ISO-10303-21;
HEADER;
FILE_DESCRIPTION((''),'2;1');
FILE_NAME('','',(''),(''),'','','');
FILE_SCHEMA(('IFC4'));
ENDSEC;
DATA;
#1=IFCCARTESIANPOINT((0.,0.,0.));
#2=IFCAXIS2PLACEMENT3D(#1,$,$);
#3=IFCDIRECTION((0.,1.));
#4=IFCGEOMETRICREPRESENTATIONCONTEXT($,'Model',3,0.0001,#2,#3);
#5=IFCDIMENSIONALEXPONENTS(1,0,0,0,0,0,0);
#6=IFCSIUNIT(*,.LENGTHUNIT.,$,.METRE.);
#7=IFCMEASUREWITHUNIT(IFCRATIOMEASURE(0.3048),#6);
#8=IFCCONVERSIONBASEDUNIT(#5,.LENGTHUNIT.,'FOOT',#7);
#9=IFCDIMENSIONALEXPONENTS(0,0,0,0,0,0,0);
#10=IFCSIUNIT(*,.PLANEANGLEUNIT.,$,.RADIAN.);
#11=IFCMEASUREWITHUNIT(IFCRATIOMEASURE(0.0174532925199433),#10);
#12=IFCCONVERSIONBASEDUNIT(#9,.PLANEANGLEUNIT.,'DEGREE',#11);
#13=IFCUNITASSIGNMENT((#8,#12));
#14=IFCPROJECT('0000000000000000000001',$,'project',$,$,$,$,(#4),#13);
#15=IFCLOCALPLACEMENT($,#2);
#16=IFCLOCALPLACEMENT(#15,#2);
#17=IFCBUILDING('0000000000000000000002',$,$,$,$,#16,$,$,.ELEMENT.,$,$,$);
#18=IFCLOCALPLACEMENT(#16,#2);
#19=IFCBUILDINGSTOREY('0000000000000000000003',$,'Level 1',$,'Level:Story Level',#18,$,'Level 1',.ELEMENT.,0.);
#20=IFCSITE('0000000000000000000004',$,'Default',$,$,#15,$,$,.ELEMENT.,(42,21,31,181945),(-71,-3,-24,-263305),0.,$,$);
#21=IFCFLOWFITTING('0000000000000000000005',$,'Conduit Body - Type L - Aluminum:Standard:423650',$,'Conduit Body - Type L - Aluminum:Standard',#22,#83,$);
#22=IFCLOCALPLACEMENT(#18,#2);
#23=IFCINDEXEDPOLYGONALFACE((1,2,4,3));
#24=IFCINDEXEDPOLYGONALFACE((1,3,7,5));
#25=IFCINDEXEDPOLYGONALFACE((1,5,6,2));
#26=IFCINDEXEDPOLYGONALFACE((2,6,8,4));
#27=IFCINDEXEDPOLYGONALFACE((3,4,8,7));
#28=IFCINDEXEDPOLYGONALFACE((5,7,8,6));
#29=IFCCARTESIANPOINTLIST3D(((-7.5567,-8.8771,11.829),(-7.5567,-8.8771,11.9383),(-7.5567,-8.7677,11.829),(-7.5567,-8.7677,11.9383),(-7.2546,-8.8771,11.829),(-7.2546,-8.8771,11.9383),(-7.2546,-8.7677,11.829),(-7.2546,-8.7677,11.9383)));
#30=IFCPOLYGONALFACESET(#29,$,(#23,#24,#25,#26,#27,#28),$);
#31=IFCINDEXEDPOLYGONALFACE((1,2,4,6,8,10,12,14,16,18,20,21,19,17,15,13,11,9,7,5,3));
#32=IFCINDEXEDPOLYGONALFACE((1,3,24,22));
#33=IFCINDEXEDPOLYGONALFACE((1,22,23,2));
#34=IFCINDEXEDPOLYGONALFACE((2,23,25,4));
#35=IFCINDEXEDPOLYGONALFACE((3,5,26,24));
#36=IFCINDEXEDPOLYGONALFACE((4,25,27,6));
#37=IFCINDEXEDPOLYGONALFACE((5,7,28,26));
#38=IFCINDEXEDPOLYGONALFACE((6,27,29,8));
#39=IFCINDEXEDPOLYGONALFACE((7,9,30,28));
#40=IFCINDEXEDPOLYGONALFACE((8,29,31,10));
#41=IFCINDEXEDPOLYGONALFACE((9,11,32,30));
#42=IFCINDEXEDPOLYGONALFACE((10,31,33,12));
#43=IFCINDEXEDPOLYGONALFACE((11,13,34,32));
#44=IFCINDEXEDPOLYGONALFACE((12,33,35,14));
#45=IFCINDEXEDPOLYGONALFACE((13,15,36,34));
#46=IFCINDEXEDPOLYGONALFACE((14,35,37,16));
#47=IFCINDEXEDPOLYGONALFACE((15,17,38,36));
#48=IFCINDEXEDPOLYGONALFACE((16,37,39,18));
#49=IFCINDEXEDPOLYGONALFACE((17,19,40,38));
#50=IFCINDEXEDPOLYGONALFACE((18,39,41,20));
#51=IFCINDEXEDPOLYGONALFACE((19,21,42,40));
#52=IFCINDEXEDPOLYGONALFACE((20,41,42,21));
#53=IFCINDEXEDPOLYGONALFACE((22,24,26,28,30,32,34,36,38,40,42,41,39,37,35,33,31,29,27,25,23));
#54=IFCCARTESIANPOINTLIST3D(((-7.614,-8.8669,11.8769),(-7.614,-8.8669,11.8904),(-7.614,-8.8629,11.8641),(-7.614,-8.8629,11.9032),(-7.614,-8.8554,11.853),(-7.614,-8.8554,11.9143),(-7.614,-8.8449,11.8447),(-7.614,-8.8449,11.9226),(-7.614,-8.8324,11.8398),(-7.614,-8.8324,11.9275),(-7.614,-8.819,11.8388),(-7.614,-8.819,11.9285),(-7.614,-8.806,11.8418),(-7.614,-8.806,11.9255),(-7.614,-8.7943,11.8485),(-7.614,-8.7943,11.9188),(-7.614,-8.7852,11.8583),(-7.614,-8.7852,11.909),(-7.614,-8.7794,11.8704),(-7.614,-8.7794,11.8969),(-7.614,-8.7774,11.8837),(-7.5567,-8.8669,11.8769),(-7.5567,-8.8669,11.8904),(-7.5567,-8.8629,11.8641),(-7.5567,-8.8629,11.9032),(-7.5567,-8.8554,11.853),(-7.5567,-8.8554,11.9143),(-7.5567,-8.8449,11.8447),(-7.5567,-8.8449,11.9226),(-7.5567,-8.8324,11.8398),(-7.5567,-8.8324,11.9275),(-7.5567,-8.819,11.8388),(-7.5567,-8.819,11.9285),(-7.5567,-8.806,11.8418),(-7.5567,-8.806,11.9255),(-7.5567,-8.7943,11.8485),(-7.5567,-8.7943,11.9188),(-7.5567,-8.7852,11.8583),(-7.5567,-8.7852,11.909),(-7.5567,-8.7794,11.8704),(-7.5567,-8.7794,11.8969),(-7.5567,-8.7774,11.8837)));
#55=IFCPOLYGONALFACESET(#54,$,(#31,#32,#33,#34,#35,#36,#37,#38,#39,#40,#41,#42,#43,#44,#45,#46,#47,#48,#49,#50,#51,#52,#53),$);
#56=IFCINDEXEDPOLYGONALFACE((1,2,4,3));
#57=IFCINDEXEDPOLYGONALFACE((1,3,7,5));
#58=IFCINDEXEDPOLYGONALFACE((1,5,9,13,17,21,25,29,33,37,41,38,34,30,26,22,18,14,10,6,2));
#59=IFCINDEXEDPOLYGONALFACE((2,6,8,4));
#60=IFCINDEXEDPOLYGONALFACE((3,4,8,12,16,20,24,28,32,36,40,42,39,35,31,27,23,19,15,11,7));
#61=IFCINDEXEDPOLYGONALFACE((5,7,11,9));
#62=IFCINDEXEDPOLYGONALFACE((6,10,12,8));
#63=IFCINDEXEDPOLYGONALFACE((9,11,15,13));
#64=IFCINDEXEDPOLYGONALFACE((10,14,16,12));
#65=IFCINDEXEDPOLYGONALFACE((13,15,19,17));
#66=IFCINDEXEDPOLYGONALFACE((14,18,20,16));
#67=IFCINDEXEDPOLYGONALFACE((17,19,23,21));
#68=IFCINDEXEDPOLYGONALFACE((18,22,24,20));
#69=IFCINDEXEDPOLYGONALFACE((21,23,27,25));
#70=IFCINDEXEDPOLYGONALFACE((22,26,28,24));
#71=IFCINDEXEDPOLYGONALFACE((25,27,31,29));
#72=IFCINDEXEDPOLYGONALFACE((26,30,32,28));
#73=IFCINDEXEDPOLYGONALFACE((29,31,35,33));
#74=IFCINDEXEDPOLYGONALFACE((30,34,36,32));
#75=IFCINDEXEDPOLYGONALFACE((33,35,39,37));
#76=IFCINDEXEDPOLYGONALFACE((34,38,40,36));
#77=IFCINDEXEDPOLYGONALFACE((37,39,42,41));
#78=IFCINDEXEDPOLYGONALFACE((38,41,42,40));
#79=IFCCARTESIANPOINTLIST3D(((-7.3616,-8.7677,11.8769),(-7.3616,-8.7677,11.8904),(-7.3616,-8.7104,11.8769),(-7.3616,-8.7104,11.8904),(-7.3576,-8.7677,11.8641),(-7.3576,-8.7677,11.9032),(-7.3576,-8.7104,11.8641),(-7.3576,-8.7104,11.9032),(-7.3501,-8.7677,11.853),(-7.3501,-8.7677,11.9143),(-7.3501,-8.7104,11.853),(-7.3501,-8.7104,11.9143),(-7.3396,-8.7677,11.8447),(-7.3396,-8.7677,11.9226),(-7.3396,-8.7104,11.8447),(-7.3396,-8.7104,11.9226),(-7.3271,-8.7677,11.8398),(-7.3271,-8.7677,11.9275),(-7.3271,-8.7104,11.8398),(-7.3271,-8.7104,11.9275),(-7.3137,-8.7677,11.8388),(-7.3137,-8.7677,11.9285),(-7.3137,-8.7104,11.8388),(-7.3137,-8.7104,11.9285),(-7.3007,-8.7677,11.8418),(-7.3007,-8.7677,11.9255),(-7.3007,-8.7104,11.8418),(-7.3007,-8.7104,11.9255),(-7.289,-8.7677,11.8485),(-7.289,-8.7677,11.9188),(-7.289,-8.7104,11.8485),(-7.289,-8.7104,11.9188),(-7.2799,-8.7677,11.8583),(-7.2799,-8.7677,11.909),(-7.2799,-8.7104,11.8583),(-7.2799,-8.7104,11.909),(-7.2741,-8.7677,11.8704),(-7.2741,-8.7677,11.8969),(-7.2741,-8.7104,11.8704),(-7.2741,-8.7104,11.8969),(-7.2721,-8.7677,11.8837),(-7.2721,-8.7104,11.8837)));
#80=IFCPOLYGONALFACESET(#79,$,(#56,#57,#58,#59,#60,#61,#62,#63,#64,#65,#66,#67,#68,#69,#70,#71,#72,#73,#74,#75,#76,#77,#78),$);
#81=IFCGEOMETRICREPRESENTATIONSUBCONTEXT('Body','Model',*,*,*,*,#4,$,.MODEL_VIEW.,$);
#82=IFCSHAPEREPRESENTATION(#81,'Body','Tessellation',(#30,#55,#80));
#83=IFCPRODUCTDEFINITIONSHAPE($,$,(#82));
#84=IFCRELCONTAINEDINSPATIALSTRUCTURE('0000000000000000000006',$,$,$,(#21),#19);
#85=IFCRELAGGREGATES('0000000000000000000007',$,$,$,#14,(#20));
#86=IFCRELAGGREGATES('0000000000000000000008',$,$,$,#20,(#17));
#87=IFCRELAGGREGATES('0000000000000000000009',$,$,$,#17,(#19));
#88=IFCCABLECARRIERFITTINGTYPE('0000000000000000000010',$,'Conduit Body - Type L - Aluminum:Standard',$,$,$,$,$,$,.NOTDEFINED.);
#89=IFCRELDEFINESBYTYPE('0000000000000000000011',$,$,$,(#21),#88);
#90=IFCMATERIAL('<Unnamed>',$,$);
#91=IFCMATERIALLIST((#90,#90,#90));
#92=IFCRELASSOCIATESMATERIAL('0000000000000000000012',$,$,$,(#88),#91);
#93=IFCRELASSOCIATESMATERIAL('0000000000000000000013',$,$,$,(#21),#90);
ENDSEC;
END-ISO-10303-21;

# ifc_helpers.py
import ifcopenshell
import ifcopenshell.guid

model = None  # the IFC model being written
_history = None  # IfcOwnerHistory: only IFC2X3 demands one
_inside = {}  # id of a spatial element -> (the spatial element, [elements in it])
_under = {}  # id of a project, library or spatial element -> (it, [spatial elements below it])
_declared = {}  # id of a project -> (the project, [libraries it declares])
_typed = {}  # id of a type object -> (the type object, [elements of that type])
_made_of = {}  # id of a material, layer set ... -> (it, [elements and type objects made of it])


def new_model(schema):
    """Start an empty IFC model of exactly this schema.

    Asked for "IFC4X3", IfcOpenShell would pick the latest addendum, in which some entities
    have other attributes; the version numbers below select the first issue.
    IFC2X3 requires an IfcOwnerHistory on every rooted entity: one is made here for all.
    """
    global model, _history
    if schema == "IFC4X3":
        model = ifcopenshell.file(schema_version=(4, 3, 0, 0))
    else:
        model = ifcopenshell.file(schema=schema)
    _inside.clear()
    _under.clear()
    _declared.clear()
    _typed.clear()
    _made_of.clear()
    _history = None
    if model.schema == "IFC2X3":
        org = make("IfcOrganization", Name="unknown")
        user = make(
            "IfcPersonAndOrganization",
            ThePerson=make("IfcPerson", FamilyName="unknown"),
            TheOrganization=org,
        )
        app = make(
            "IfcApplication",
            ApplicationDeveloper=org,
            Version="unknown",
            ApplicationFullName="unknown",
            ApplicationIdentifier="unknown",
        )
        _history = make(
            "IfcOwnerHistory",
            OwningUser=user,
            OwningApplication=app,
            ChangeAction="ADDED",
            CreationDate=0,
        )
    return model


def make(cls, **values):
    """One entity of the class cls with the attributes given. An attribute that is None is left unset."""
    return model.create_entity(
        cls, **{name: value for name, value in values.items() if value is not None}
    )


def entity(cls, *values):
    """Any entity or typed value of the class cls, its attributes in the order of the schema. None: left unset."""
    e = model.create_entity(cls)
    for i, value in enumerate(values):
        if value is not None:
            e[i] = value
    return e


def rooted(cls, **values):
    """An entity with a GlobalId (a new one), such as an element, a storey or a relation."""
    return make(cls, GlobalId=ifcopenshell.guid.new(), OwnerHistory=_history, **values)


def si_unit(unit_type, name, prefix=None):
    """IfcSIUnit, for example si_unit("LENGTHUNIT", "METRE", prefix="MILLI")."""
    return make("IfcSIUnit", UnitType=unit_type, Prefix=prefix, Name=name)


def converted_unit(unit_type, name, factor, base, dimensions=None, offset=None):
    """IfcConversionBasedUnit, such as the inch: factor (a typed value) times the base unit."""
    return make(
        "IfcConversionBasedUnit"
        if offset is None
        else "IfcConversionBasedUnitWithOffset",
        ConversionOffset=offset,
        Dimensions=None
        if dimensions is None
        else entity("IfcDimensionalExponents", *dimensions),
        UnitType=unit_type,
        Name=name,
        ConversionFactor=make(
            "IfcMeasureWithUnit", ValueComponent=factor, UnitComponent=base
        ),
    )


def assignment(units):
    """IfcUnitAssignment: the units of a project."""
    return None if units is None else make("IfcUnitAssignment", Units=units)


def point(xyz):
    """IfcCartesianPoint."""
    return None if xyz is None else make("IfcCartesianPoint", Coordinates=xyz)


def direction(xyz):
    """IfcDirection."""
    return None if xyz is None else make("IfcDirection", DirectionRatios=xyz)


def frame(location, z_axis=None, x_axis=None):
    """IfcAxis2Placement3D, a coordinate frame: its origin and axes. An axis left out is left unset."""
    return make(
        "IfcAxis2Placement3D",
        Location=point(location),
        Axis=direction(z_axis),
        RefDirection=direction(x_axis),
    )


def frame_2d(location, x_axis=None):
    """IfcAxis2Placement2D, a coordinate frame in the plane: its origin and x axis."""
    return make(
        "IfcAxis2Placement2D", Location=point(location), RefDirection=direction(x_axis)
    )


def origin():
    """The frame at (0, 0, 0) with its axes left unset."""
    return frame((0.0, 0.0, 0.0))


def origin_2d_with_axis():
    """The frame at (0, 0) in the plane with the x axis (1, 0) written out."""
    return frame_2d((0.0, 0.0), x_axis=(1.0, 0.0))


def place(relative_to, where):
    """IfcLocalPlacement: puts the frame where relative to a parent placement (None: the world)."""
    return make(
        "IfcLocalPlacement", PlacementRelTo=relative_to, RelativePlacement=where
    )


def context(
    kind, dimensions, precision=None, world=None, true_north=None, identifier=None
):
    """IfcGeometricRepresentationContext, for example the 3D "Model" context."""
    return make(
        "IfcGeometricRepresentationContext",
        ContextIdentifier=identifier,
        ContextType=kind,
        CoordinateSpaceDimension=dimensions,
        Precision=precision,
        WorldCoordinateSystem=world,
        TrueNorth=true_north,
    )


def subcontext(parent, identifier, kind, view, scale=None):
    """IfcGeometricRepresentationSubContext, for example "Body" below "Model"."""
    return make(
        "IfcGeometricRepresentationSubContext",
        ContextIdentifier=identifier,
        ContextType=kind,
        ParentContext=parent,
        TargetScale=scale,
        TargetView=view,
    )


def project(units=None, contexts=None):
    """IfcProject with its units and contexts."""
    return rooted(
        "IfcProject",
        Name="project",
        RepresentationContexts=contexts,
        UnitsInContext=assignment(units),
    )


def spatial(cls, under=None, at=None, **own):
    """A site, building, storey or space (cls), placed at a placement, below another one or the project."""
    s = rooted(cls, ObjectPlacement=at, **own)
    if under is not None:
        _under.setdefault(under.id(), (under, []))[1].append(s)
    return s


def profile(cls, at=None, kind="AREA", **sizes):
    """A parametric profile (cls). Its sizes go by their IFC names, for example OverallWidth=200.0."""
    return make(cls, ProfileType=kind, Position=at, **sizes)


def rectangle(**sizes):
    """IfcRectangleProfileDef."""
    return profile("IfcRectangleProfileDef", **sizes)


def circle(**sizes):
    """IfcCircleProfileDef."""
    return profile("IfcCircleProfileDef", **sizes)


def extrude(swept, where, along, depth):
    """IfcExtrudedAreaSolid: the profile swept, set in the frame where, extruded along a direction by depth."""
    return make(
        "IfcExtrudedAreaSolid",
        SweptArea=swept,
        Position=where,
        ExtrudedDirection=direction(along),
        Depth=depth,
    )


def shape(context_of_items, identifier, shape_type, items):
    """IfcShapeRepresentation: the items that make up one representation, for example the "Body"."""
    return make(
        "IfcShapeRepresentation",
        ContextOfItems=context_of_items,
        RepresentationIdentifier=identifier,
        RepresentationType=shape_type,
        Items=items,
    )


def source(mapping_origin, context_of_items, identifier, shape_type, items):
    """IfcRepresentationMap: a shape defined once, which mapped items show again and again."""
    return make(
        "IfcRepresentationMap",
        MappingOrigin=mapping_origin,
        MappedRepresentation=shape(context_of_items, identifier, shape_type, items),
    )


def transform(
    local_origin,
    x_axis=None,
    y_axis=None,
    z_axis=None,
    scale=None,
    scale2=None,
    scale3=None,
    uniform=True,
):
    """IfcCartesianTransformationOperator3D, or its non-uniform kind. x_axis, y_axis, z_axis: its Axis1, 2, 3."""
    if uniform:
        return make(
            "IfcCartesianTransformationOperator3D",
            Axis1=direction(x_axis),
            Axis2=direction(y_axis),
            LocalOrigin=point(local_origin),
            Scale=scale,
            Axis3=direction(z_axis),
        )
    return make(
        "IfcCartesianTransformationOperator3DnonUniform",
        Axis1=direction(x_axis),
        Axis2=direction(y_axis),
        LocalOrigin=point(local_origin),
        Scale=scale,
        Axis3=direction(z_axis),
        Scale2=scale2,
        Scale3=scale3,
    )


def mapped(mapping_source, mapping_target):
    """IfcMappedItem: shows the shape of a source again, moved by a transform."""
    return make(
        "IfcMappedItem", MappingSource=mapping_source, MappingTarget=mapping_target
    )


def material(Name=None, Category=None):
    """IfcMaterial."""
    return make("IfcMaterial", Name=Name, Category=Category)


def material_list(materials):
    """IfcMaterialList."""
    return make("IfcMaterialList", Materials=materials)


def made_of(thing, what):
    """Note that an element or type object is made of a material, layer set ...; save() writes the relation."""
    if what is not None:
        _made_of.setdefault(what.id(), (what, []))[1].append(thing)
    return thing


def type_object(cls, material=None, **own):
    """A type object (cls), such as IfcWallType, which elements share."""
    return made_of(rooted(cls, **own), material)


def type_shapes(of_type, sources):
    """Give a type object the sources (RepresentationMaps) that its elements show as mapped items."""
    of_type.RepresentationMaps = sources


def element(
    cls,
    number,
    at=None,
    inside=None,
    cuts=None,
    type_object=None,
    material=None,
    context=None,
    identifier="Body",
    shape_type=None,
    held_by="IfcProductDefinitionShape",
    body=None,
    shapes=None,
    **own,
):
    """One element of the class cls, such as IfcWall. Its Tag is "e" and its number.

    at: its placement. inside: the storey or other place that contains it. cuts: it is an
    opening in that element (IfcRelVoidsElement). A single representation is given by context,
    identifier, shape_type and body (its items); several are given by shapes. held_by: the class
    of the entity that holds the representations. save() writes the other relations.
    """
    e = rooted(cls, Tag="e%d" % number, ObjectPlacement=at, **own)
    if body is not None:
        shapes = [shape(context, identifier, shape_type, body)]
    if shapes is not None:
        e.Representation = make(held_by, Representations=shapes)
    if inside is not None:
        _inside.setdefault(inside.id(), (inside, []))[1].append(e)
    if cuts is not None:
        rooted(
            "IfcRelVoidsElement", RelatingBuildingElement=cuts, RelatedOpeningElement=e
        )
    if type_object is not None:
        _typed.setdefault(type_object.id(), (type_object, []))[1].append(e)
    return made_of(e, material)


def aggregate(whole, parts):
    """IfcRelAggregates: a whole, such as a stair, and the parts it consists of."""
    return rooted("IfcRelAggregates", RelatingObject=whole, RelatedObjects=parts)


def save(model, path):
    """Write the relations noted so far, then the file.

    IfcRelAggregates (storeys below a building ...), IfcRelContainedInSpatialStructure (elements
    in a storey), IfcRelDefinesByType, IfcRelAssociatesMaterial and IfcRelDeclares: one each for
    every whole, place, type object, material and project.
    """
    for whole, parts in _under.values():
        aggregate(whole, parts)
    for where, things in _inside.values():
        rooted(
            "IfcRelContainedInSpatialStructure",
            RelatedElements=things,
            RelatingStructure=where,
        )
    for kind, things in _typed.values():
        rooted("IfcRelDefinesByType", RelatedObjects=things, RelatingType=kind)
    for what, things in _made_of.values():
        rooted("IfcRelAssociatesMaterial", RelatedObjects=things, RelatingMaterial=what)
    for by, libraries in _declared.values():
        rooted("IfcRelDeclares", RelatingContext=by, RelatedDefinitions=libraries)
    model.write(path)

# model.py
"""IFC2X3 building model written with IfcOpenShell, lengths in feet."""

from ifc_helpers import new_model, entity, si_unit, converted_unit, direction, frame, frame_2d, origin, origin_2d_with_axis, place, context, subcontext, project, spatial, rectangle, circle, extrude, source, transform, mapped, material, material_list, type_object, type_shapes, element, save


model = new_model("IFC2X3")

# Units and contexts
model_context = context("Model", 3, precision=0.0001, world=origin(), true_north=direction((0.0, 1.0)))
body_context = subcontext(model_context, "Body", "Model", "MODEL_VIEW")
ifc_project = project(units=[converted_unit("LENGTHUNIT", "FOOT", entity("IfcRatioMeasure", 0.3048), si_unit("LENGTHUNIT", "METRE"), dimensions=[1, 0, 0, 0, 0, 0, 0]), converted_unit("PLANEANGLEUNIT", "DEGREE", entity("IfcRatioMeasure", 0.0174532925199433), si_unit("PLANEANGLEUNIT", "RADIAN"), dimensions=[0, 0, 0, 0, 0, 0, 0])], contexts=[model_context])

# Site, building, storey
site_placement = place(None, origin())
site = spatial("IfcSite", under=ifc_project, at=site_placement, Name="Default", CompositionType="ELEMENT", RefLatitude=(42, 21, 31, 181945), RefLongitude=(-71, -3, -24, -263305), RefElevation=0.0)
building_placement = place(site_placement, origin())
building = spatial("IfcBuilding", under=site, at=building_placement, CompositionType="ELEMENT")
storey_placement = place(building_placement, origin())
storey = spatial("IfcBuildingStorey", under=building, at=storey_placement, Name="Level 1", ObjectType="Level:Story Level", LongName="Level 1", CompositionType="ELEMENT", Elevation=0.0)

# Shared definitions
ifc_material_1 = material(Name="<Unnamed>")

# Flow fitting
ifc_material_list_1 = material_list([ifc_material_1, ifc_material_1, ifc_material_1])
cable_carrier_fitting_type = type_object("IfcCableCarrierFittingType", Name="Conduit Body - Type L - Aluminum:Standard", PredefinedType="NOTDEFINED", material=ifc_material_list_1)
shared_shape_1 = source(origin(), body_context, "Body", "SweptSolid", [
    extrude(rectangle(XDim=0.3021, YDim=0.1094, at=origin_2d_with_axis()), frame((-0.0885, 0.0, -0.0547), z_axis=(0.0, 0.0, 1.0), x_axis=(-1.0, 0.0, 0.0)), (0.0, 0.0, 1.0), 0.1094),
    extrude(circle(Radius=0.045, at=frame_2d((0.0, 0.0), x_axis=(1.0, 0.0))), frame((-0.2969, 0.0, 0.0), z_axis=(1.0, 0.0, 0.0), x_axis=(0.0, 1.0, 0.0)), (0.0, 0.0, 1.0), 0.0573),
    extrude(circle(Radius=0.045, at=frame_2d((0.0, 0.0), x_axis=(1.0, 0.0))), frame((0.0, 0.0547, 0.0), z_axis=(0.0, 1.0, 0.0), x_axis=(1.0, 0.0, 0.0)), (0.0, 0.0, 1.0), 0.0573),
])
type_shapes(cable_carrier_fitting_type, [shared_shape_1])
for number, where, name in (
    (1, (-7.3171, -8.8224, 11.8837), "Conduit Body - Type L - Aluminum:Standard:423650"),
):
    element("IfcFlowFitting", number, at=place(storey_placement, frame(where)), inside=storey, type_object=cable_carrier_fitting_type, material=ifc_material_1, Name=name, ObjectType="Conduit Body - Type L - Aluminum:Standard", context=body_context, shape_type="MappedRepresentation", body=[
        mapped(shared_shape_1, transform((0.0, 0.0, 0.0), scale=1.0)),
    ])

save(model, "model.ifc")
